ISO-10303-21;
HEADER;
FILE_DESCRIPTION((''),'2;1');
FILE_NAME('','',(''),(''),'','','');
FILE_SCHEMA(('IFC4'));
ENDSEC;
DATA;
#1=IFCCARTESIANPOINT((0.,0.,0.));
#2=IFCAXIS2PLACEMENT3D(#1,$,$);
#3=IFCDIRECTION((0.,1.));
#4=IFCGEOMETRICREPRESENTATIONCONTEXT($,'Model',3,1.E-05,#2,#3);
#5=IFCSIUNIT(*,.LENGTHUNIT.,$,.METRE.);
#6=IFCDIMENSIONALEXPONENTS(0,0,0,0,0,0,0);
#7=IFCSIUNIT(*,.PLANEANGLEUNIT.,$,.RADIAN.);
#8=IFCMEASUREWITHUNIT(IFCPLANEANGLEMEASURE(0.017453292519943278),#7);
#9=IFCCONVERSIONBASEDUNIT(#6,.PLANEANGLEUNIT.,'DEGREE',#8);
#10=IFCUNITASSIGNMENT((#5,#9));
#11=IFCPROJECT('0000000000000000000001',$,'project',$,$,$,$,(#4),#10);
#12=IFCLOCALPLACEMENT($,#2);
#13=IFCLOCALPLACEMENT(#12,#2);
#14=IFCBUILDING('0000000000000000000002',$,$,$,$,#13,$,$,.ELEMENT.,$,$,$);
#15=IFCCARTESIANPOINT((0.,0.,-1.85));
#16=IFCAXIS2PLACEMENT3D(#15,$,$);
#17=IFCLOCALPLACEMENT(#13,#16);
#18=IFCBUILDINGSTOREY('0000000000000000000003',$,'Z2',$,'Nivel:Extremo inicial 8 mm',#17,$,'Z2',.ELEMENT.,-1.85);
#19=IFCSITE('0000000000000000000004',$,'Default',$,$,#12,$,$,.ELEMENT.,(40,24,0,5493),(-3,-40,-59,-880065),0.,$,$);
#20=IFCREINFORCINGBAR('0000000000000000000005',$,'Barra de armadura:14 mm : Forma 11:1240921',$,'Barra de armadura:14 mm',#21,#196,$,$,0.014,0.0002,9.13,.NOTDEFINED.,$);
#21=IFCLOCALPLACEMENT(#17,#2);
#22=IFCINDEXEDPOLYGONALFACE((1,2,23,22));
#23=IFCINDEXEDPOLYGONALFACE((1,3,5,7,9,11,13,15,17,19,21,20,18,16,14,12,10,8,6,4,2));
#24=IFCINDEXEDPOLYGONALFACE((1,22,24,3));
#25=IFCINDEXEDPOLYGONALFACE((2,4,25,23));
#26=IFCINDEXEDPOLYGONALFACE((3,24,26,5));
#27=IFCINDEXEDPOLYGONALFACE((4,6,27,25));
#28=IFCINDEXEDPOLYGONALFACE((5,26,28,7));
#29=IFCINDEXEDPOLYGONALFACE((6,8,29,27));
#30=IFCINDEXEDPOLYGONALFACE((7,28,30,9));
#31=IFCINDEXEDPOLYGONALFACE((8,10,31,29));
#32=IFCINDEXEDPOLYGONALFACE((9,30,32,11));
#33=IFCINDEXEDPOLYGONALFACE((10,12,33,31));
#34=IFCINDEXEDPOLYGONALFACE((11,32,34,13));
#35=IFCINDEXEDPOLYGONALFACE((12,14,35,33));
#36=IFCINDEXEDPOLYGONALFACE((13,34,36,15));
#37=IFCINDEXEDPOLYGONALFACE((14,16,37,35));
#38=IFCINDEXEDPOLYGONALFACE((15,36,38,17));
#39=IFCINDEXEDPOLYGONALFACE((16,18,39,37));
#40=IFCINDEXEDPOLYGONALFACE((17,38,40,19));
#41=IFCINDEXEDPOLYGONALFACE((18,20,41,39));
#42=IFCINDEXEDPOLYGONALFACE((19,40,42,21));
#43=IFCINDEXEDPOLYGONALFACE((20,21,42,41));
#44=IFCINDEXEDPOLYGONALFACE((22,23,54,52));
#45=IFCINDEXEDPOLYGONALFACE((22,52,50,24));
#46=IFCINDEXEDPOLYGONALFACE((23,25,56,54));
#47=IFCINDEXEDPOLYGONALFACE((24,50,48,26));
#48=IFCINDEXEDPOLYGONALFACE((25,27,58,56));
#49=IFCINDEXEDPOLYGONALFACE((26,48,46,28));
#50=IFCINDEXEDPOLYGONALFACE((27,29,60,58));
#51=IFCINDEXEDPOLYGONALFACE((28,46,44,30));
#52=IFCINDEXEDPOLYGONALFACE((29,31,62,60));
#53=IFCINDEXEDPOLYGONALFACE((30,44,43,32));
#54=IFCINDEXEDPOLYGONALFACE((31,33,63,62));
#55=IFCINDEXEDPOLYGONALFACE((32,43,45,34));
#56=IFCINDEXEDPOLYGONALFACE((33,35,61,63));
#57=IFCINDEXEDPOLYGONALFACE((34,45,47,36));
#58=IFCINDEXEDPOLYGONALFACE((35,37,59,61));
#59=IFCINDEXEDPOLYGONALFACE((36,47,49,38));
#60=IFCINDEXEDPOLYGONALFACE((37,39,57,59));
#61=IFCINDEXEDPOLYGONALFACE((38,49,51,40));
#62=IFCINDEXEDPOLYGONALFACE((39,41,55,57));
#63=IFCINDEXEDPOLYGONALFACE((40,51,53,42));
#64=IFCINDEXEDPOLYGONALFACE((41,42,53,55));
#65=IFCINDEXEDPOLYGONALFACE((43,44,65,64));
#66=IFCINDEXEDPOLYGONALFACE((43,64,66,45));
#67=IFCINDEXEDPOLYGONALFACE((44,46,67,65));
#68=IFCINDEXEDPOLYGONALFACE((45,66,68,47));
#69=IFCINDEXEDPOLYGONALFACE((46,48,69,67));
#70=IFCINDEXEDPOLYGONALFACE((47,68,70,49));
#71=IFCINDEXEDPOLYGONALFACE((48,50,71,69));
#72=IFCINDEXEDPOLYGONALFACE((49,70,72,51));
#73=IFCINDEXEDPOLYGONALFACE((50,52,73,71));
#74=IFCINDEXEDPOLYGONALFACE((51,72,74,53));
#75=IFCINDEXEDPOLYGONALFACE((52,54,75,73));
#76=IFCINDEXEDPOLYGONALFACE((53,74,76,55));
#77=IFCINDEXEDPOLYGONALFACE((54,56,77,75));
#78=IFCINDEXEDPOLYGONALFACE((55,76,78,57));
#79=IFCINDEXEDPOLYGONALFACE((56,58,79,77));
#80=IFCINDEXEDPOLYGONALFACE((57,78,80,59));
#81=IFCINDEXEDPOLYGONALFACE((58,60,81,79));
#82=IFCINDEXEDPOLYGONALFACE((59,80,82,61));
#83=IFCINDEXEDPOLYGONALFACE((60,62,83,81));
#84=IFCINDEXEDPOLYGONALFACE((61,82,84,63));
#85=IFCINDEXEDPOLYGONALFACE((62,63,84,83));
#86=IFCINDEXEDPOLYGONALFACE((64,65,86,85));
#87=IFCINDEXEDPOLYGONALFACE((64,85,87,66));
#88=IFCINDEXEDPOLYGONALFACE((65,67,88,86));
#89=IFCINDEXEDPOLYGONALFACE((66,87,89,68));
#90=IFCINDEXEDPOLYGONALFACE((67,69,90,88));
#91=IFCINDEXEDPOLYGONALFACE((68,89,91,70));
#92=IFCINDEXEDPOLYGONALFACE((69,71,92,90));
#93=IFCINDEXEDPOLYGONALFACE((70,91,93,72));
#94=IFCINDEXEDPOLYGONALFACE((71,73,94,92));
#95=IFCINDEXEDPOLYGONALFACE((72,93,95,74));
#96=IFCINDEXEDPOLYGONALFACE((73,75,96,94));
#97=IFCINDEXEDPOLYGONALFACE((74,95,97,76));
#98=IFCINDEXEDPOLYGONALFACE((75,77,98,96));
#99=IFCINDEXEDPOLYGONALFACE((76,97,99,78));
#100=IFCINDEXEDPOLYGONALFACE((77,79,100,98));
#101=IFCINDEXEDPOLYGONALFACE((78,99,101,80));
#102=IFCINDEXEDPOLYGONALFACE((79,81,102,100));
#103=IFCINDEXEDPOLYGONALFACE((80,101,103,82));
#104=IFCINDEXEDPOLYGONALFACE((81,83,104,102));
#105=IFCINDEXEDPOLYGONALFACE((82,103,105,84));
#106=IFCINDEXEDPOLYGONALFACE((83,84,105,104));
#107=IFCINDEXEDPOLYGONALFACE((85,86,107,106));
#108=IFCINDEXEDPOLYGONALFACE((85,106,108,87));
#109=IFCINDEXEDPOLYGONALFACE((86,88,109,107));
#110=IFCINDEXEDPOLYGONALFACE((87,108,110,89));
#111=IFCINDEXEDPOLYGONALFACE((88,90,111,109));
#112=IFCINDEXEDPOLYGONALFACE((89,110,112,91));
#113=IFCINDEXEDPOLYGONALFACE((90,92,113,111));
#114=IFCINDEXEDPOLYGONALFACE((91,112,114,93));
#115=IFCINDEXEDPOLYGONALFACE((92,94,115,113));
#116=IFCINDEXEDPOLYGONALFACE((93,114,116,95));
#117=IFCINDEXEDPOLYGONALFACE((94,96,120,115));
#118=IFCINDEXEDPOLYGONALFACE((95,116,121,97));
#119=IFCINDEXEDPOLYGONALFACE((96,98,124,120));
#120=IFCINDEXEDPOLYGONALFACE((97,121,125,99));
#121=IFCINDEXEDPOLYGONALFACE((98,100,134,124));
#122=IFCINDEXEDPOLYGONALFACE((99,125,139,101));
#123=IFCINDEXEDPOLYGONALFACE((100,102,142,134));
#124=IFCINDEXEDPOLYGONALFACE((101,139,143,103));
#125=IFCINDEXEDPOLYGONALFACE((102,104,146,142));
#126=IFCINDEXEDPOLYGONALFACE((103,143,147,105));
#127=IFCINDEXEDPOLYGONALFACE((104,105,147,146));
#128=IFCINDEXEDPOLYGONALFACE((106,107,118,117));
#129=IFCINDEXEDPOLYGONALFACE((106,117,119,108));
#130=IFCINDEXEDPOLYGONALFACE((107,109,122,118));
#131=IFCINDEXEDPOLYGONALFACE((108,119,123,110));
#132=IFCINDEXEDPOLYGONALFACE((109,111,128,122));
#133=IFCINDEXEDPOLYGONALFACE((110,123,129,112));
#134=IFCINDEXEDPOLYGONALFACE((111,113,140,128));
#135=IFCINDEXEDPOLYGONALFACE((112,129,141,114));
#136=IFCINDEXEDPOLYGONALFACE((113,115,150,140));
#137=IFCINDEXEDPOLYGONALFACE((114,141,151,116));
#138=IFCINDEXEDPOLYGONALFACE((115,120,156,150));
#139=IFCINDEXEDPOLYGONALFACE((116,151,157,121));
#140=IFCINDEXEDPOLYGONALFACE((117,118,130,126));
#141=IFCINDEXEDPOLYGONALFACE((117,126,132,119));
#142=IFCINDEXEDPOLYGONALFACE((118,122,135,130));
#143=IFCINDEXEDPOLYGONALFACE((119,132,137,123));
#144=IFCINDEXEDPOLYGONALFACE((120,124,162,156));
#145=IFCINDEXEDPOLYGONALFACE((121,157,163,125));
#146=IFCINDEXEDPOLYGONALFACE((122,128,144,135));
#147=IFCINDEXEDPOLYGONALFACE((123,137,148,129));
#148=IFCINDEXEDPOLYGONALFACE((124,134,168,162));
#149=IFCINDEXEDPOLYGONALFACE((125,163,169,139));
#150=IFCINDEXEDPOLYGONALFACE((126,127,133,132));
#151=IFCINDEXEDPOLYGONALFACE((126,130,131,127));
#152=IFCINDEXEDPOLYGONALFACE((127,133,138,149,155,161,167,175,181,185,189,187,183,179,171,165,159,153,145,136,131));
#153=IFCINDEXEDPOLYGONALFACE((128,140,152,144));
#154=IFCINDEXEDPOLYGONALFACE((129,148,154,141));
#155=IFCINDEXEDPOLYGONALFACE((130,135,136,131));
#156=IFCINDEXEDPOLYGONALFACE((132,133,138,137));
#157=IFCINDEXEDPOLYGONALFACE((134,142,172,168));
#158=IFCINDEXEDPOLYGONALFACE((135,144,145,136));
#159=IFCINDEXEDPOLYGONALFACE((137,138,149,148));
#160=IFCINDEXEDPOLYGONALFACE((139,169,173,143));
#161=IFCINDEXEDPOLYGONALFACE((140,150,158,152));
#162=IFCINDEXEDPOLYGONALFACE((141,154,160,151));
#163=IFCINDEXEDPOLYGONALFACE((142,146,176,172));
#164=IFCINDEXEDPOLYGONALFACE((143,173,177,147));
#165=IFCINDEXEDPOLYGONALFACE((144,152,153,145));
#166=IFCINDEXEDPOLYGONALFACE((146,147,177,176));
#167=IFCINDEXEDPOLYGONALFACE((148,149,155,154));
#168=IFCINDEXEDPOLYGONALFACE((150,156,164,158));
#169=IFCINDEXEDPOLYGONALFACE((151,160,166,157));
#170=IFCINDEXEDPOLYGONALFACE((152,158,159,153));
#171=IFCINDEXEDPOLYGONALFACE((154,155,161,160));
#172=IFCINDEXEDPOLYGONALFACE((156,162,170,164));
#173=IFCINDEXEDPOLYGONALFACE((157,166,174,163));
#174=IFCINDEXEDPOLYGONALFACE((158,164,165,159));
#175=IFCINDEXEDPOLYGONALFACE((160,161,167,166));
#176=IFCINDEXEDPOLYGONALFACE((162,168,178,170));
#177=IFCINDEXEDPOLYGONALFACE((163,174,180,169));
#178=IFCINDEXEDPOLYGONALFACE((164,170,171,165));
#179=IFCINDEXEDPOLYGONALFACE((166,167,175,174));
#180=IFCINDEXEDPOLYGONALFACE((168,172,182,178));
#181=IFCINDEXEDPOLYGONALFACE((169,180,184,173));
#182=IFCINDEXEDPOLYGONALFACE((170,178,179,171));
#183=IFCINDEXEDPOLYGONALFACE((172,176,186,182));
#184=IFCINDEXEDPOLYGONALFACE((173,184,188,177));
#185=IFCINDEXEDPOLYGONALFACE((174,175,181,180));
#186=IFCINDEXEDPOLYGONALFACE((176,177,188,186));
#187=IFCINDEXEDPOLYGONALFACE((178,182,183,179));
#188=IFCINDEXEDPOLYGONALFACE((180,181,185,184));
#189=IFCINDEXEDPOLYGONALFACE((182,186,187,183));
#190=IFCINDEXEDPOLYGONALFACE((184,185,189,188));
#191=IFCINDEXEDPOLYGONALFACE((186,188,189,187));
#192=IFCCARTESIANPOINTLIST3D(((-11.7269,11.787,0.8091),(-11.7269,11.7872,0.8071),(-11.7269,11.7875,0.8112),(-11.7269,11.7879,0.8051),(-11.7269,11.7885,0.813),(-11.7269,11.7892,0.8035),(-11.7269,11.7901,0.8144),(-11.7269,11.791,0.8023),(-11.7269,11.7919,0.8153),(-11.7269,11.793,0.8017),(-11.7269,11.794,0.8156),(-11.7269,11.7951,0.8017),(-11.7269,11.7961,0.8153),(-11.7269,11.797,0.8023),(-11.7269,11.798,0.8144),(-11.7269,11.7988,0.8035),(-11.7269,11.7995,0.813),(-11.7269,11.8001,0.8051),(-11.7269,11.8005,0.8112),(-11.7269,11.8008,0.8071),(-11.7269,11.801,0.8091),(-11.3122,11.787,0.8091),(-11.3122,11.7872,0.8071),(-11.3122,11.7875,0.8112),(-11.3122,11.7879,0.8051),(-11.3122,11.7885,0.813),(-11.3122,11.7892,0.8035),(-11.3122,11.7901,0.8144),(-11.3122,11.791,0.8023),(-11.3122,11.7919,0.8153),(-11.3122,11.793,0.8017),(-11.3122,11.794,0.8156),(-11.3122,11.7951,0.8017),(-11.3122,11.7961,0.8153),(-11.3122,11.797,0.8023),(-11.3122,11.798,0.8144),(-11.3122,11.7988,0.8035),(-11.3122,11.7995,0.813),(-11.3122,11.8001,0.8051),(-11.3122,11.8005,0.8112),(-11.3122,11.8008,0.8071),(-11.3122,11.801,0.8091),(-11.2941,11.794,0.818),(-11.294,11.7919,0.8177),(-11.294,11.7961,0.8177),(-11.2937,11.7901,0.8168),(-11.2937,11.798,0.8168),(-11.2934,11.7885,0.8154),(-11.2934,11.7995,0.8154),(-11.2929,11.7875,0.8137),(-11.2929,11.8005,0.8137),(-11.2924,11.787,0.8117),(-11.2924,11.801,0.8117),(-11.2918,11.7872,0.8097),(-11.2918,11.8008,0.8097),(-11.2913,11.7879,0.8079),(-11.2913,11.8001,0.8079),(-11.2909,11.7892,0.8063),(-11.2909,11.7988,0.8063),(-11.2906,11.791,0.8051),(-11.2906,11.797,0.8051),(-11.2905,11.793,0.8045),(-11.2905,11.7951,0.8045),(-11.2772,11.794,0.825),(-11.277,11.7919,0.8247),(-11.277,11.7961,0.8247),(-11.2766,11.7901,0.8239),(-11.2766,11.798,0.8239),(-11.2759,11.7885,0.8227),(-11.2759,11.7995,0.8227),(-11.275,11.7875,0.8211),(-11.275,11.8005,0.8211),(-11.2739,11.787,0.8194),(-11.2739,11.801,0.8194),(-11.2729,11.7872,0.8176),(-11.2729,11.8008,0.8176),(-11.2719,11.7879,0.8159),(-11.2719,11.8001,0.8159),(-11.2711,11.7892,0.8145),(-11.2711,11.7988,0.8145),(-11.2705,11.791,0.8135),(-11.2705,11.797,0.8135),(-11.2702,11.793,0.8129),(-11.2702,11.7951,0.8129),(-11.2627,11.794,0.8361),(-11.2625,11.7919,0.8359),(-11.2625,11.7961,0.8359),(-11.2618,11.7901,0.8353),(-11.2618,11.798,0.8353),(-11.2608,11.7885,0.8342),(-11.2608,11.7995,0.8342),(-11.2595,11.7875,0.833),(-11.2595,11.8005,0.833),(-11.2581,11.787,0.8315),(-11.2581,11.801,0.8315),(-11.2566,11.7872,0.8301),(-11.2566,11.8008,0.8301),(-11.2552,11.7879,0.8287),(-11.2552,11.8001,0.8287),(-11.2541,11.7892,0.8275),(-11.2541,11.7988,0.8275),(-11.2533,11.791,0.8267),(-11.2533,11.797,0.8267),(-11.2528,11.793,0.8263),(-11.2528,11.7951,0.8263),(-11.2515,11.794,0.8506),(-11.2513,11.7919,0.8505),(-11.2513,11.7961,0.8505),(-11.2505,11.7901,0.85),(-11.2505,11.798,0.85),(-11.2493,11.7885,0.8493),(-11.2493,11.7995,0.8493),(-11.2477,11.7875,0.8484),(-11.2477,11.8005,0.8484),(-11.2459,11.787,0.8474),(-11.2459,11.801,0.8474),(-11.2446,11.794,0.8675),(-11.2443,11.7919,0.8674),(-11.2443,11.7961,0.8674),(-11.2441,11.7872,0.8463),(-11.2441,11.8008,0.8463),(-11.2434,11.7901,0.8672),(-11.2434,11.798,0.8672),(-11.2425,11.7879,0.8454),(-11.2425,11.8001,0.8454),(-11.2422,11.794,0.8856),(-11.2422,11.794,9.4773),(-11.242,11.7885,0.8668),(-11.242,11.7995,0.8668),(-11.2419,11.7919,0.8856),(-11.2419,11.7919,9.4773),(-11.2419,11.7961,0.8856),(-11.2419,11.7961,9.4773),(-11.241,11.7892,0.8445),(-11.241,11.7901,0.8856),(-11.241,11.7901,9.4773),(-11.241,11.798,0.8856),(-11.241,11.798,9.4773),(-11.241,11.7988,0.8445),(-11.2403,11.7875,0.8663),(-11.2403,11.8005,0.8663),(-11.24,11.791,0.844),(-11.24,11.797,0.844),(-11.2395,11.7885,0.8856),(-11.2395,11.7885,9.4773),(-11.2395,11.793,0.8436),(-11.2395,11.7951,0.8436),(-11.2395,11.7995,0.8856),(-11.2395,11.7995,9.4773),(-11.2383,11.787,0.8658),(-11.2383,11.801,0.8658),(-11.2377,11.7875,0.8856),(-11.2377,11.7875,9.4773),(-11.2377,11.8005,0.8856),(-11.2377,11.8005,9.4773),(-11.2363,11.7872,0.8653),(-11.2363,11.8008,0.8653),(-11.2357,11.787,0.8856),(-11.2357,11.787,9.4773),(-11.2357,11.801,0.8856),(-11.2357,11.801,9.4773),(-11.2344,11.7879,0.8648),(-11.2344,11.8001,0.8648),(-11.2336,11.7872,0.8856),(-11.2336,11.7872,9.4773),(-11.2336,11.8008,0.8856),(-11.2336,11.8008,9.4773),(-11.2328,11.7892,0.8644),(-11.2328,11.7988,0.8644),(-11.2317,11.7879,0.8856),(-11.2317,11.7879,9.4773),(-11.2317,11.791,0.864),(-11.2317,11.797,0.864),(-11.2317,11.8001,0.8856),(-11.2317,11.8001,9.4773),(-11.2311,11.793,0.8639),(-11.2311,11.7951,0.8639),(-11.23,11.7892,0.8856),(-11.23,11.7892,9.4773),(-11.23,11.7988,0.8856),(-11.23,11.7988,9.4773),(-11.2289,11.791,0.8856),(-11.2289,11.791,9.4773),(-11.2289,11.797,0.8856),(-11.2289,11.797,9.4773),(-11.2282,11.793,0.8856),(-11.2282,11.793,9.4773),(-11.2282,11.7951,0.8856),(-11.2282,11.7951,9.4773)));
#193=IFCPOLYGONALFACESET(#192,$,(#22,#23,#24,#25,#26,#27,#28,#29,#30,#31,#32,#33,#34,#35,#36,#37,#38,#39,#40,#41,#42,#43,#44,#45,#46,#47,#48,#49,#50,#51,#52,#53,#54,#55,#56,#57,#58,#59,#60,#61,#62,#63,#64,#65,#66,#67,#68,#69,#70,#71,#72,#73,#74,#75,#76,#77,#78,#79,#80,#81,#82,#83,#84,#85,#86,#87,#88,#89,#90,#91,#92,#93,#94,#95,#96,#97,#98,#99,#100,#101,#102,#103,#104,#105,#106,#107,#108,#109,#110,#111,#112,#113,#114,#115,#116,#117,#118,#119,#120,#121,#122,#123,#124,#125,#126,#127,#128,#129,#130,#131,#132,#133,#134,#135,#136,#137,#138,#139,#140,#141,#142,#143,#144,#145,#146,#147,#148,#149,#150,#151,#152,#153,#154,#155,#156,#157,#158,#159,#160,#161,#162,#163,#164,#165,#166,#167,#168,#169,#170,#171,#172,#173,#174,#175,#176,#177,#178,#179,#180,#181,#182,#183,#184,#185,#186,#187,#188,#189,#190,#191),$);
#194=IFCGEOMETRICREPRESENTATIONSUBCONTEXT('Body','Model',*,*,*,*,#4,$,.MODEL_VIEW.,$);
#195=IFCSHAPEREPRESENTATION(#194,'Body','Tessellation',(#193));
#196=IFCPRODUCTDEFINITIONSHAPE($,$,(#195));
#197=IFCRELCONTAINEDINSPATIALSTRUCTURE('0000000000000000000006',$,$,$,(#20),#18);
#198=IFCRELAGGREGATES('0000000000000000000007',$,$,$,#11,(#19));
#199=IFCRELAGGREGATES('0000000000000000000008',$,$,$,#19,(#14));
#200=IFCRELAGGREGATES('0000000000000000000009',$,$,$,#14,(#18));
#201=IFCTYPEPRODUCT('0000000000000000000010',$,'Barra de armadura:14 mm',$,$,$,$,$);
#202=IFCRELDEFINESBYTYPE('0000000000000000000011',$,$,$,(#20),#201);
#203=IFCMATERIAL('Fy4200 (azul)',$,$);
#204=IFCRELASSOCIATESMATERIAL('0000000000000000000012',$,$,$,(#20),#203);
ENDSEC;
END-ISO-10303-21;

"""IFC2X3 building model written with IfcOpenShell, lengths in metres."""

from ifc_helpers import new_model, entity, si_unit, converted_unit, direction, frame, origin, place, context, subcontext, project, spatial, material, type_object, element, save


model = new_model("IFC2X3")

# Units and contexts
model_context = context("Model", 3, precision=1e-05, world=origin(), true_north=direction((0.0, 1.0)))
body_context = subcontext(model_context, "Body", "Model", "MODEL_VIEW")
ifc_project = project(units=[si_unit("LENGTHUNIT", "METRE"), converted_unit("PLANEANGLEUNIT", "DEGREE", entity("IfcPlaneAngleMeasure", 0.017453292519943278), si_unit("PLANEANGLEUNIT", "RADIAN"), dimensions=[0, 0, 0, 0, 0, 0, 0])], contexts=[model_context])

# Site, building, storey
site_placement = place(None, origin())
site = spatial("IfcSite", under=ifc_project, at=site_placement, Name="Default", CompositionType="ELEMENT", RefLatitude=(40, 24, 0, 5493), RefLongitude=(-3, -40, -59, -880065), RefElevation=0.0)
building_placement = place(site_placement, origin())
building = spatial("IfcBuilding", under=site, at=building_placement, CompositionType="ELEMENT")
storey_placement = place(building_placement, frame((0.0, 0.0, -1.85)))
storey = spatial("IfcBuildingStorey", under=building, at=storey_placement, Name="Z2", ObjectType="Nivel:Extremo inicial 8 mm", LongName="Z2", CompositionType="ELEMENT", Elevation=-1.85)

# Reinforcing bar
ifc_material_1 = material(Name="Fy4200 (azul)")
type_product_1 = type_object("IfcTypeProduct", Name="Barra de armadura:14 mm")
reinforcing_bar_1_placement = place(storey_placement, origin())
element("IfcReinforcingBar", 1, at=reinforcing_bar_1_placement, inside=storey, type_object=type_product_1, material=ifc_material_1, Name="Barra de armadura:14 mm : Forma 11:1240921", ObjectType="Barra de armadura:14 mm", BarLength=9.13, BarRole="NOTDEFINED", CrossSectionArea=0.0002, NominalDiameter=0.014, context=body_context, shape_type="AdvancedSweptSolid", body=[
    entity("IfcSweptDiskSolid", entity("IfcCompositeCurve", [entity("IfcCompositeCurveSegment", "CONTINUOUS", True, entity("IfcPolyline", [entity("IfcCartesianPoint", [-11.2352, 11.794, 9.4773]), entity("IfcCartesianPoint", [-11.2352, 11.794, 0.8856])])), entity("IfcCompositeCurveSegment", "CONTINUOUS", True, entity("IfcTrimmedCurve", entity("IfcCircle", entity("IfcAxis2Placement3D", entity("IfcCartesianPoint", [-11.3122, 11.794, 0.8856]), entity("IfcDirection", [0.0, 1.0, 0.0]), entity("IfcDirection", [0.0, 0.0, -1.0])), 0.077), [entity("IfcParameterValue", 270.0)], [entity("IfcParameterValue", 360.0)], True, "PARAMETER")), entity("IfcCompositeCurveSegment", "CONTINUOUS", True, entity("IfcPolyline", [entity("IfcCartesianPoint", [-11.3122, 11.794, 0.8086]), entity("IfcCartesianPoint", [-11.7269, 11.794, 0.8086])]))], False), 0.007, None, 0.0, 92.0),
])

save(model, "model.ifc")
